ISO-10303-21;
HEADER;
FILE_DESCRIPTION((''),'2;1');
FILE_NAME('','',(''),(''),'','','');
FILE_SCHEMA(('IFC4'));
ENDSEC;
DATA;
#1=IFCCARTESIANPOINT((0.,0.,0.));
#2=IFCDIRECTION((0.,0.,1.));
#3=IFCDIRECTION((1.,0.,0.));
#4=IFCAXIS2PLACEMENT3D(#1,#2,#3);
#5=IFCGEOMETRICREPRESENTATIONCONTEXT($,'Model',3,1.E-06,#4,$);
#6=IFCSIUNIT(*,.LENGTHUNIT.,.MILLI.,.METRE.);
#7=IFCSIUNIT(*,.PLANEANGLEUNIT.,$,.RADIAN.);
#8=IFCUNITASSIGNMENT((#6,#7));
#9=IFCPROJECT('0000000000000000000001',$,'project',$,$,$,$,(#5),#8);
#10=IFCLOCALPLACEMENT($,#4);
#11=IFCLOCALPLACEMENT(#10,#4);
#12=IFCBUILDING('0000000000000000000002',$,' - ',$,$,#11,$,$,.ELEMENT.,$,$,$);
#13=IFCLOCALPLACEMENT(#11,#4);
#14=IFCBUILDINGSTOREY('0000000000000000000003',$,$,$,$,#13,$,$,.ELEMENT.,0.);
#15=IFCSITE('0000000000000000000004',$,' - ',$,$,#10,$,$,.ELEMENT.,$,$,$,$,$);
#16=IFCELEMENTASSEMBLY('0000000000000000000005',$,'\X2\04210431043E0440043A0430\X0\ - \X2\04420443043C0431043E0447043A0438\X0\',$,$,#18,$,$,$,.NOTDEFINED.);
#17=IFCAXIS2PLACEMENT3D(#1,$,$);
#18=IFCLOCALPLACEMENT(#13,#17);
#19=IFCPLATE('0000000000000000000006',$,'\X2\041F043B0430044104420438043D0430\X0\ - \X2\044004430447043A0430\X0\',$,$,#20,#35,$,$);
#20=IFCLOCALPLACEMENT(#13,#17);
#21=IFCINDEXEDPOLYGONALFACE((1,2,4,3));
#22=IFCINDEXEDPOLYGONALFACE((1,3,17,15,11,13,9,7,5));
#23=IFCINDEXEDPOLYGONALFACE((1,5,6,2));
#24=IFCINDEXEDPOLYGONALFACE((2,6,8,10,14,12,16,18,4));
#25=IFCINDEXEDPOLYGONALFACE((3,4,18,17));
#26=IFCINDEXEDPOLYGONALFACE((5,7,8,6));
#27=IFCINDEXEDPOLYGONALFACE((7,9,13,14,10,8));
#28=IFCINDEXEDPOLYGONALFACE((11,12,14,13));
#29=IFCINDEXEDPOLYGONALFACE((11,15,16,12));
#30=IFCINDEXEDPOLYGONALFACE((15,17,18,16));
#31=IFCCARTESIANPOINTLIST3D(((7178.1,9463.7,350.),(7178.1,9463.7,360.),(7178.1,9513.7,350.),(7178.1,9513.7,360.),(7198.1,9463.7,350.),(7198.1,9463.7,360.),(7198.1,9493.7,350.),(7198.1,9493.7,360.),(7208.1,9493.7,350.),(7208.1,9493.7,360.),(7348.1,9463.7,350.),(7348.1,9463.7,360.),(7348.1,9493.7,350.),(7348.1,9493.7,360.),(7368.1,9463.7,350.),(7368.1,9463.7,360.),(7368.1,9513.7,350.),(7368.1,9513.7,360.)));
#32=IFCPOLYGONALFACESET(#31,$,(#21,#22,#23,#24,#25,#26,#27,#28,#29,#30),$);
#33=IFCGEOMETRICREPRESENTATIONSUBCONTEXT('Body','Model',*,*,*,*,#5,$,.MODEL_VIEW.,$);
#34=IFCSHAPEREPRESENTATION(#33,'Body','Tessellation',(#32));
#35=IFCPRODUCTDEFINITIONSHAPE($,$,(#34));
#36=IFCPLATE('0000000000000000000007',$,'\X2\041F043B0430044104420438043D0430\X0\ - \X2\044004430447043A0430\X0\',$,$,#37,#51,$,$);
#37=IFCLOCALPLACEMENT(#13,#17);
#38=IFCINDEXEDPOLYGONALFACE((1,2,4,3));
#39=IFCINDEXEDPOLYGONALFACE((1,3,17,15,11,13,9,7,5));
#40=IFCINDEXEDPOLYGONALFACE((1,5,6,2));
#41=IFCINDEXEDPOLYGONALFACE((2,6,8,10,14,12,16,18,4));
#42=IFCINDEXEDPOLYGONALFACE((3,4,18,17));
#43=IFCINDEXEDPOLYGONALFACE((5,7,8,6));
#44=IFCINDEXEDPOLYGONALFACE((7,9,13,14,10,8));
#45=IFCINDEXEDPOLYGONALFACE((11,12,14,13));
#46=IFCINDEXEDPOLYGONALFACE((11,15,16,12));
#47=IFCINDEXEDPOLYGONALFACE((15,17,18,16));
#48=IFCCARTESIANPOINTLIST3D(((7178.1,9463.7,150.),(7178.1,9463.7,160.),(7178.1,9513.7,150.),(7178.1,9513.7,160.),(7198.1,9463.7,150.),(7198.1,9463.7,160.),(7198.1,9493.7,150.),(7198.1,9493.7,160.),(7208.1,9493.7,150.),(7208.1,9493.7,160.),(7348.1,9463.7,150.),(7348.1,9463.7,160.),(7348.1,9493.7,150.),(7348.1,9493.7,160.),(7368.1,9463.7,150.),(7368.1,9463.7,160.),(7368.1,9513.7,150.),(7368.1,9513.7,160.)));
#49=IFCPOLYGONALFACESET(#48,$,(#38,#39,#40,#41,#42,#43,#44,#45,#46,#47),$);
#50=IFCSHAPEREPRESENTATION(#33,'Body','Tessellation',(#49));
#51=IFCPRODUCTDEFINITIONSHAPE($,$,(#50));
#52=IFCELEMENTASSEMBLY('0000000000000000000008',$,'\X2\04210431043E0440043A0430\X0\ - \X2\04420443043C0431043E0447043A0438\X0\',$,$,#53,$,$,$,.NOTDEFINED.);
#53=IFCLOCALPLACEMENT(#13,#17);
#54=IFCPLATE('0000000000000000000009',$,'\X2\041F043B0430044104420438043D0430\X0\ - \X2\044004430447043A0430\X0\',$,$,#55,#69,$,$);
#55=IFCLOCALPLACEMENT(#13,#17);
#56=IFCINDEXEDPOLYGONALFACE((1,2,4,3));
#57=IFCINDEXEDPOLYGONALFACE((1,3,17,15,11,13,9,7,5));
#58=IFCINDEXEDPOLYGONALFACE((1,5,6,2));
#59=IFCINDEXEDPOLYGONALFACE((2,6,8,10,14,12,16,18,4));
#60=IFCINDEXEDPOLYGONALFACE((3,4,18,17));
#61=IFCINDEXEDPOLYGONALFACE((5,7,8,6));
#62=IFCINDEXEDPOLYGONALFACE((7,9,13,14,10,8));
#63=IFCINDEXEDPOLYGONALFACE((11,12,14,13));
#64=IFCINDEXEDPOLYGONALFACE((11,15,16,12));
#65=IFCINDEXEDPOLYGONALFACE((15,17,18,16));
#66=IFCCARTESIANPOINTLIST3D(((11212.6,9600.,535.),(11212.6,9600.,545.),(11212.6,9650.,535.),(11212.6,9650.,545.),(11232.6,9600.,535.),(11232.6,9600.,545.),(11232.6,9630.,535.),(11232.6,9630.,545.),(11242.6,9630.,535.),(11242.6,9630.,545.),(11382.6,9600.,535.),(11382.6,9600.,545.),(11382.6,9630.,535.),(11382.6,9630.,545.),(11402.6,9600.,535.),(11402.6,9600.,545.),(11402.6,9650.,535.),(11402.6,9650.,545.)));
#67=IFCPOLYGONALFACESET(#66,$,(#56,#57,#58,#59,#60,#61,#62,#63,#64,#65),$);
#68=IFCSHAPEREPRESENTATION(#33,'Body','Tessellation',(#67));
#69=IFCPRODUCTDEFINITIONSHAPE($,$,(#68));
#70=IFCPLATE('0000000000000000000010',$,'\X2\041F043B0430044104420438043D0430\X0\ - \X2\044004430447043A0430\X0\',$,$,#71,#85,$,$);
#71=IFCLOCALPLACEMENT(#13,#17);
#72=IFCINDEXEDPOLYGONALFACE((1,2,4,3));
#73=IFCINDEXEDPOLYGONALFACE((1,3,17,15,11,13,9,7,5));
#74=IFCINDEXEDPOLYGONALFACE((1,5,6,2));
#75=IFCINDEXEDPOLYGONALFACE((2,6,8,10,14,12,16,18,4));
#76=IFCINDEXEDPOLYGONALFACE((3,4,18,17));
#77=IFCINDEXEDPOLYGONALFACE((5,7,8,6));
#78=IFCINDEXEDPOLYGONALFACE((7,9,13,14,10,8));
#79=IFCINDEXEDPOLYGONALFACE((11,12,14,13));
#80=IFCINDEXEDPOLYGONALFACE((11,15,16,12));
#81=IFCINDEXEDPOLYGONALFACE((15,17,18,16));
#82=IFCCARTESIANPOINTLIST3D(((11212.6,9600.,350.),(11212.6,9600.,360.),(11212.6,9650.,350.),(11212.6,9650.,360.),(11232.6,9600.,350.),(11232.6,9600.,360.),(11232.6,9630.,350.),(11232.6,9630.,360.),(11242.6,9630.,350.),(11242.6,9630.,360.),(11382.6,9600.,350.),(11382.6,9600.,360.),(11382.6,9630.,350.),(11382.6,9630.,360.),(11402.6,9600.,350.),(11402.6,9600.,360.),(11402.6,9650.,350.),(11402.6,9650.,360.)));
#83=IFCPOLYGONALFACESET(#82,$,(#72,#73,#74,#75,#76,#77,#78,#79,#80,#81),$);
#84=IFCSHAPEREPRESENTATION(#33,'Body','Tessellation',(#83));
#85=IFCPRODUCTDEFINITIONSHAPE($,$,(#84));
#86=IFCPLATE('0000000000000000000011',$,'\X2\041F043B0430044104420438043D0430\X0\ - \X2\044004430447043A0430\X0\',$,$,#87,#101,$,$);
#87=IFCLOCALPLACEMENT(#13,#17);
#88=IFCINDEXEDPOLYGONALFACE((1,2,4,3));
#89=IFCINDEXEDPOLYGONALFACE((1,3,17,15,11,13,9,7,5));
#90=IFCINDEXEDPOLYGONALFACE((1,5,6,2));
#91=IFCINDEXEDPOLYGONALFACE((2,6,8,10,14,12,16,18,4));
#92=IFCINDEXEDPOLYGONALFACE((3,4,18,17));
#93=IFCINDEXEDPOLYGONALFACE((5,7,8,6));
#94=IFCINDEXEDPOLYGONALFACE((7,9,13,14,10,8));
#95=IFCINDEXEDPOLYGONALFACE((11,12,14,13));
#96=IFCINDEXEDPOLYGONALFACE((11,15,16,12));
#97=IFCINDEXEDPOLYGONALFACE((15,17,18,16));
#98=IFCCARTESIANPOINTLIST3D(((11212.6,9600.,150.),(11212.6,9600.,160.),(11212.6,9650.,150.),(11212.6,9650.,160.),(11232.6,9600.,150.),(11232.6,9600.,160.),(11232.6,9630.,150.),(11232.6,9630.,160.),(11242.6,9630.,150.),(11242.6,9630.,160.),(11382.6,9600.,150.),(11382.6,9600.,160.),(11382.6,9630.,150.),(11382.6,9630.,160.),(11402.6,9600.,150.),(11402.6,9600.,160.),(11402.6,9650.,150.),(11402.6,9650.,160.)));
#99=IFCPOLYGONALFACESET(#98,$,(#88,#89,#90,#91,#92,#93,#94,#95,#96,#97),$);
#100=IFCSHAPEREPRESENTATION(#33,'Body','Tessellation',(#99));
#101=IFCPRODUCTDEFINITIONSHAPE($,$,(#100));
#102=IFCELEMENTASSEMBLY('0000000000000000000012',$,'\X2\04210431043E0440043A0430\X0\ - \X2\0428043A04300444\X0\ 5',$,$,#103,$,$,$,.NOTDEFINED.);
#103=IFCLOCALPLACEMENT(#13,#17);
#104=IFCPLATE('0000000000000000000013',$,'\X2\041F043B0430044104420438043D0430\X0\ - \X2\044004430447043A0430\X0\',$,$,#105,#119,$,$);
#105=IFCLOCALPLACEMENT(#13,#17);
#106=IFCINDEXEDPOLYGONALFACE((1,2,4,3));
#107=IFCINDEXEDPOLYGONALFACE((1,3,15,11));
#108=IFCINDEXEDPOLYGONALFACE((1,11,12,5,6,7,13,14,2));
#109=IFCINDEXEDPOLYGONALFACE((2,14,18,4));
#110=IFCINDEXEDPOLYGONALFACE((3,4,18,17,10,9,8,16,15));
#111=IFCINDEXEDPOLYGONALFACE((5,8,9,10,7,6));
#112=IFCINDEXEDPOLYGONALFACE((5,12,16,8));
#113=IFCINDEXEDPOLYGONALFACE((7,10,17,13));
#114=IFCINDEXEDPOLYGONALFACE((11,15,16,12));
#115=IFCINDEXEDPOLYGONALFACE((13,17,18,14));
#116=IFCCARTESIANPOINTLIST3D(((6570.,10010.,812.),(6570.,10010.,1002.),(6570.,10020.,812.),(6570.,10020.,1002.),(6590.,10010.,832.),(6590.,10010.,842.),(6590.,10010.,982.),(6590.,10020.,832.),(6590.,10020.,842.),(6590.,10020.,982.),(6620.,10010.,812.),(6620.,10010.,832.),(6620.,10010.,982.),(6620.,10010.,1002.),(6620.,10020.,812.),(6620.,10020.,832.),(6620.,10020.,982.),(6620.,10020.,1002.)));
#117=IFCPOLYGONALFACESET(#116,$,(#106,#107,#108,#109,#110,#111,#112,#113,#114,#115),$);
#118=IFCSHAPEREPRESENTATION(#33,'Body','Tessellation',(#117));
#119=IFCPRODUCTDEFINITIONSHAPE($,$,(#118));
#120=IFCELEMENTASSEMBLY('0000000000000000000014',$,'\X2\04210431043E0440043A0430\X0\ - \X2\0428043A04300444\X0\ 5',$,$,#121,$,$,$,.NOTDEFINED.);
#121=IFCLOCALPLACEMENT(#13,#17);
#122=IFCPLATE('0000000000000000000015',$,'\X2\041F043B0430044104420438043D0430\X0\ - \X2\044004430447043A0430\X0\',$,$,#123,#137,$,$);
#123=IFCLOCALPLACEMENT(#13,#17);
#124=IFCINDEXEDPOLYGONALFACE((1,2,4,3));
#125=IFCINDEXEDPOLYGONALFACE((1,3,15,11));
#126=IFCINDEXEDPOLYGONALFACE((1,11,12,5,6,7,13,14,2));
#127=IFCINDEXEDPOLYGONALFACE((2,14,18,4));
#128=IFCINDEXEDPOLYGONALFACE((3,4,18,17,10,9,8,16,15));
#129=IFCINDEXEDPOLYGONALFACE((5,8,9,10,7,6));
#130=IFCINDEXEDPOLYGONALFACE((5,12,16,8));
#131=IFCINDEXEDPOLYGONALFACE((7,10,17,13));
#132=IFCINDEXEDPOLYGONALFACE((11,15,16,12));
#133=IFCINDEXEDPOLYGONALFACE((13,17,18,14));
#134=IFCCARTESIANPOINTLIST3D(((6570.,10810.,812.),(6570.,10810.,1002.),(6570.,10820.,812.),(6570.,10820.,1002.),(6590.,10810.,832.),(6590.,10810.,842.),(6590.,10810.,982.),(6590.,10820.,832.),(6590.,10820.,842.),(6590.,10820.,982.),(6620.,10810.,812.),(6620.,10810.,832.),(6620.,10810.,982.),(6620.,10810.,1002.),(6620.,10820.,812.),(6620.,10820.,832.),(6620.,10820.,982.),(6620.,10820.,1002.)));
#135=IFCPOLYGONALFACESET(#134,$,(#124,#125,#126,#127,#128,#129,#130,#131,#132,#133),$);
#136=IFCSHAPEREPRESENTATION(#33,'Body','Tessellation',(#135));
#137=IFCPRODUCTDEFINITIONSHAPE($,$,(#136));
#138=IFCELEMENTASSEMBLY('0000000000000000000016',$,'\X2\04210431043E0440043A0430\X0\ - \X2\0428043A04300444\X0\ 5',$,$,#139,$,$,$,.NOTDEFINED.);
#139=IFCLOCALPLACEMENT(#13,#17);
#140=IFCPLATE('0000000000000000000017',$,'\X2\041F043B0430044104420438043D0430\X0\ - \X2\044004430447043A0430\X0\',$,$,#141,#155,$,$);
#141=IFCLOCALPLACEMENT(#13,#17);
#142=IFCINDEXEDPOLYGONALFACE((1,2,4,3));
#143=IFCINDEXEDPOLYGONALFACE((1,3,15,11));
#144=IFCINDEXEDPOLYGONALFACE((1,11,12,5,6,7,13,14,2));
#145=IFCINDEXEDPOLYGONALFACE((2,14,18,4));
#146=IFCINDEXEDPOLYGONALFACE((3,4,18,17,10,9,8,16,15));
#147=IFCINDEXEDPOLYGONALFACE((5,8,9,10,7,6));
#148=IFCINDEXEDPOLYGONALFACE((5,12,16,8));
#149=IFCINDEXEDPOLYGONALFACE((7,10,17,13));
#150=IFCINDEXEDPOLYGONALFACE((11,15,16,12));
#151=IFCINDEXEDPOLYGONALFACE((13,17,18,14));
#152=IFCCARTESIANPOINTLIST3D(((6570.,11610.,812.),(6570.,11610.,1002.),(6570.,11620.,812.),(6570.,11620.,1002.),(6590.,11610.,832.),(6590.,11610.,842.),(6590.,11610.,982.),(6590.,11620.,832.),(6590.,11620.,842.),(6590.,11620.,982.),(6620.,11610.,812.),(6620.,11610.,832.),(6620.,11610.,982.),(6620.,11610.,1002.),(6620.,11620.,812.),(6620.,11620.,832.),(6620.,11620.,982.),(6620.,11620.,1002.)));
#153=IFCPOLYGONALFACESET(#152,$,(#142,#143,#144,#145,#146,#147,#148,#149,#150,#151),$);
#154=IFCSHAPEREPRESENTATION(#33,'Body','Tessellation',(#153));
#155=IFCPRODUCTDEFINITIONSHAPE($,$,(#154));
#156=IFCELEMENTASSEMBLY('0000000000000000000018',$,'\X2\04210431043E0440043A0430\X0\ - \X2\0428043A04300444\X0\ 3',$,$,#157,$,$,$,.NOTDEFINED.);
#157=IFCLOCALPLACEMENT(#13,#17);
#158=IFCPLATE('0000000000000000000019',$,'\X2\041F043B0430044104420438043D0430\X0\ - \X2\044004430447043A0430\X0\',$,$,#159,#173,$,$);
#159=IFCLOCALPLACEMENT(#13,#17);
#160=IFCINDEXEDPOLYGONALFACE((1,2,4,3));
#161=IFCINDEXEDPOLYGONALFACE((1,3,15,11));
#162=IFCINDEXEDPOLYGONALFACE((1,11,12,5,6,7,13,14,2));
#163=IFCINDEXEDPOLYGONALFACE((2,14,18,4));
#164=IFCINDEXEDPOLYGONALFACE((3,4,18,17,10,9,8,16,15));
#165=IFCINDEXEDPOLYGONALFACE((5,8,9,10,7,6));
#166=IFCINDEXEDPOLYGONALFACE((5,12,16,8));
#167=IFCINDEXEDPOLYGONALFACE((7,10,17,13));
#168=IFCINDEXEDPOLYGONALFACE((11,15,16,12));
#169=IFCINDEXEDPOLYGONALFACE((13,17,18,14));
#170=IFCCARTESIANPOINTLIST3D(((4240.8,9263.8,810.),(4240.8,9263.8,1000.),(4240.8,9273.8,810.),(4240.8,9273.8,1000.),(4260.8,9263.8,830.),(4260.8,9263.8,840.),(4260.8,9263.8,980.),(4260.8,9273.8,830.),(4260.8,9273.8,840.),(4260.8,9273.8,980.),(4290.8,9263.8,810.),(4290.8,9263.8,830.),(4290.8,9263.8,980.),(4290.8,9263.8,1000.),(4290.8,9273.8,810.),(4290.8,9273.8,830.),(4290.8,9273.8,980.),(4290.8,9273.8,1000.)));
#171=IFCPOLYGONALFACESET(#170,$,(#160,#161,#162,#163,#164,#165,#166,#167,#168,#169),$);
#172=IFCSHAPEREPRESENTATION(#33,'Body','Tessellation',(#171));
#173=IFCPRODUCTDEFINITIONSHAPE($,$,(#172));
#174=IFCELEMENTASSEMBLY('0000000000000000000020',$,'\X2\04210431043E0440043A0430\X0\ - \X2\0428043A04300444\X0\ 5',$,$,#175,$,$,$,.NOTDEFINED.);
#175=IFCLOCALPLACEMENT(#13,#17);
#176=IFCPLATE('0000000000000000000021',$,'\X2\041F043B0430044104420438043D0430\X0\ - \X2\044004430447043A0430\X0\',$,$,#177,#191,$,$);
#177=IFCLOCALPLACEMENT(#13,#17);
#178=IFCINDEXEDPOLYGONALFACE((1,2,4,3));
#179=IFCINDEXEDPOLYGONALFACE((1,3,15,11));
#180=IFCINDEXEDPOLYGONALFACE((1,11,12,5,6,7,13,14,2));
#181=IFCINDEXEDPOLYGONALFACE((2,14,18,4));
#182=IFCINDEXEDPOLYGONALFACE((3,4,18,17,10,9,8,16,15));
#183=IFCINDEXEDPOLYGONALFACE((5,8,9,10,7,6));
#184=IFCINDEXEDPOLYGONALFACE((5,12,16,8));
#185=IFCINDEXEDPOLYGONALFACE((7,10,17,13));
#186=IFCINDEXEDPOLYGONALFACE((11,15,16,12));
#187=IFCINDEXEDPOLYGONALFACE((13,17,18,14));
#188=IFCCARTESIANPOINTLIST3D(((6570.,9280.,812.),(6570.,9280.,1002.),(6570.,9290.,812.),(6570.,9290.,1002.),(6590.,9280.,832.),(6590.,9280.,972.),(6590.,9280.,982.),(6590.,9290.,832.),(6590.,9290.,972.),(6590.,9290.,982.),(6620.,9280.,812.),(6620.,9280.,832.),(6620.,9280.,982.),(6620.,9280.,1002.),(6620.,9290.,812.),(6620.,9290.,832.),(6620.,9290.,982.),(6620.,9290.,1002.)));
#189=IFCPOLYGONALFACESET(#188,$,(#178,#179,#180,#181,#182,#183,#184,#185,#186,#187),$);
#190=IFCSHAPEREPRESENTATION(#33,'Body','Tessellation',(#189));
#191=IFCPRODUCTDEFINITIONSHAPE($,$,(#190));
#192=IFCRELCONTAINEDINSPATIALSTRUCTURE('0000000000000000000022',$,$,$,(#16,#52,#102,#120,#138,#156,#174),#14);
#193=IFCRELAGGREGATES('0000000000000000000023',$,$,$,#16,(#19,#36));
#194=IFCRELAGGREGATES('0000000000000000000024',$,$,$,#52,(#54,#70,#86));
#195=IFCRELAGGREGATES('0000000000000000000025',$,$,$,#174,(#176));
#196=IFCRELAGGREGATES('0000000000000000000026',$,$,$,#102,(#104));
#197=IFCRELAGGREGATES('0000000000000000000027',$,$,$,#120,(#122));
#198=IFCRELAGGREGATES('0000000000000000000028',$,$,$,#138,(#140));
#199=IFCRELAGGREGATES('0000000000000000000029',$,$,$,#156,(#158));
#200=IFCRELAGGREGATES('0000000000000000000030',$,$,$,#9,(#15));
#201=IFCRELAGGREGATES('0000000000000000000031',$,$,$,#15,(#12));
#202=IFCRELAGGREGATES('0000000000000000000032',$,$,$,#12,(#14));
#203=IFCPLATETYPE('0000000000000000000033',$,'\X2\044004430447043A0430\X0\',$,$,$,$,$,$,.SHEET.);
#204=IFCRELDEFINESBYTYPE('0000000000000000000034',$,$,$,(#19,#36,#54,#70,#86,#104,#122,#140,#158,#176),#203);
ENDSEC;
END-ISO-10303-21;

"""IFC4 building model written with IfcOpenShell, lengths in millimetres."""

from ifc_helpers import new_model, si_unit, frame, origin_with_axes, place, context, subcontext, project, spatial, line, indexed_curve, outline, extrude, source, transform, mapped, type_object, element, aggregate, save


model = new_model("IFC4")

# Units and contexts
model_context = context("Model", 3, precision=1e-06, world=origin_with_axes())
body_context = subcontext(model_context, "Body", "Model", "MODEL_VIEW")
ifc_project = project(units=[si_unit("LENGTHUNIT", "METRE", prefix="MILLI"), si_unit("PLANEANGLEUNIT", "RADIAN")], contexts=[model_context])

# Site, building, storey
site_placement = place(None, origin_with_axes())
site = spatial("IfcSite", under=ifc_project, at=site_placement, Name=" - ", CompositionType="ELEMENT")
building_placement = place(site_placement, origin_with_axes())
building = spatial("IfcBuilding", under=site, at=building_placement, Name=" - ", CompositionType="ELEMENT")
storey_placement = place(building_placement, origin_with_axes())
storey = spatial("IfcBuildingStorey", under=building, at=storey_placement, CompositionType="ELEMENT", Elevation=0.0)

# Shared definitions
plate_type = type_object("IfcPlateType", Name="ручка", PredefinedType="SHEET")
shared_shape_1 = source(origin_with_axes(), body_context, "Body", "SweptSolid", [
    extrude(outline(indexed_curve([(-95.0, -25.0), (-75.0, -25.0), (-75.0, 5.0), (-65.0, 5.0), (75.0, 5.0), (75.0, -25.0), (95.0, -25.0), (95.0, 25.0), (-95.0, 25.0)], segments=[line(1, 2), line(2, 3), line(3, 4), line(4, 5), line(5, 6), line(6, 7), line(7, 8), line(8, 9), line(9, 1)])), origin_with_axes(), (0.0, 0.0, 1.0), 10.0),
])

# Element assemblies, plates
assembly_1_placement = place(storey_placement, frame((7473.1, 9463.7, 0.0), z_axis=(0.0, 0.0, 1.0), x_axis=(-1.0, 0.0, 0.0)))
assembly_1 = element("IfcElementAssembly", 1, at=assembly_1_placement, inside=storey, Name="Сборка - тумбочки", PredefinedType="NOTDEFINED")
plate_1_placement = place(assembly_1_placement, frame((200.0, -25.0, 350.0), z_axis=(0.0, 0.0, 1.0), x_axis=(-1.0, 0.0, 0.0)))
plate_1 = element("IfcPlate", 2, at=plate_1_placement, type_object=plate_type, Name="Пластина - ручка", context=body_context, shape_type="MappedRepresentation", body=[
    mapped(shared_shape_1, transform((0.0, 0.0, 0.0), x_axis=(1.0, 0.0, 0.0), y_axis=(0.0, 1.0, 0.0), z_axis=(0.0, 0.0, 1.0), scale=1.0)),
])
plate_2_placement = place(assembly_1_placement, frame((200.0, -25.0, 150.0), z_axis=(0.0, 0.0, 1.0), x_axis=(-1.0, 0.0, 0.0)))
plate_2 = element("IfcPlate", 3, at=plate_2_placement, type_object=plate_type, Name="Пластина - ручка", context=body_context, shape_type="MappedRepresentation", body=[
    mapped(shared_shape_1, transform((0.0, 0.0, 0.0), x_axis=(1.0, 0.0, 0.0), y_axis=(0.0, 1.0, 0.0), z_axis=(0.0, 0.0, 1.0), scale=1.0)),
])
aggregate(assembly_1, [plate_1, plate_2])
assembly_2_placement = place(storey_placement, frame((11507.6, 9600.0, 0.0), z_axis=(0.0, 0.0, 1.0), x_axis=(-1.0, 0.0, 0.0)))
assembly_2 = element("IfcElementAssembly", 4, at=assembly_2_placement, inside=storey, Name="Сборка - тумбочки", PredefinedType="NOTDEFINED")
plate_3_placement = place(assembly_2_placement, frame((200.0, -25.0, 535.0), z_axis=(0.0, 0.0, 1.0), x_axis=(-1.0, 0.0, 0.0)))
plate_3 = element("IfcPlate", 5, at=plate_3_placement, type_object=plate_type, Name="Пластина - ручка", context=body_context, shape_type="MappedRepresentation", body=[
    mapped(shared_shape_1, transform((0.0, 0.0, 0.0), x_axis=(1.0, 0.0, 0.0), y_axis=(0.0, 1.0, 0.0), z_axis=(0.0, 0.0, 1.0), scale=1.0)),
])
plate_4_placement = place(assembly_2_placement, frame((200.0, -25.0, 350.0), z_axis=(0.0, 0.0, 1.0), x_axis=(-1.0, 0.0, 0.0)))
plate_4 = element("IfcPlate", 6, at=plate_4_placement, type_object=plate_type, Name="Пластина - ручка", context=body_context, shape_type="MappedRepresentation", body=[
    mapped(shared_shape_1, transform((0.0, 0.0, 0.0), x_axis=(1.0, 0.0, 0.0), y_axis=(0.0, 1.0, 0.0), z_axis=(0.0, 0.0, 1.0), scale=1.0)),
])
plate_5_placement = place(assembly_2_placement, frame((200.0, -25.0, 150.0), z_axis=(0.0, 0.0, 1.0), x_axis=(-1.0, 0.0, 0.0)))
plate_5 = element("IfcPlate", 7, at=plate_5_placement, type_object=plate_type, Name="Пластина - ручка", context=body_context, shape_type="MappedRepresentation", body=[
    mapped(shared_shape_1, transform((0.0, 0.0, 0.0), x_axis=(1.0, 0.0, 0.0), y_axis=(0.0, 1.0, 0.0), z_axis=(0.0, 0.0, 1.0), scale=1.0)),
])
aggregate(assembly_2, [plate_3, plate_4, plate_5])

# Element assemblies, plates
assembly_3_placement = place(storey_placement, frame((6620.0, 10450.0, 2.0), z_axis=(0.0, 0.0, 1.0), x_axis=(0.0, -1.0, 0.0)))
assembly_3 = element("IfcElementAssembly", 8, at=assembly_3_placement, inside=storey, Name="Сборка - Шкаф 5", PredefinedType="NOTDEFINED")
shared_shape_2 = source(origin_with_axes(), body_context, "Body", "SweptSolid", [
    extrude(outline(indexed_curve([(-95.0, -25.0), (-75.0, -25.0), (-75.0, 5.0), (-65.0, 5.0), (75.0, 5.0), (75.0, -25.0), (95.0, -25.0), (95.0, 25.0), (-95.0, 25.0)], segments=[line(1, 2), line(2, 3), line(3, 4), line(4, 5), line(5, 6), line(6, 7), line(7, 8), line(8, 9), line(9, 1)])), origin_with_axes(), (0.0, 0.0, 1.0), 10.0),
])
plate_6_placement = place(assembly_3_placement, frame((430.0, -25.0, 905.0), z_axis=(1.0, 0.0, 0.0), x_axis=(0.0, 0.0, 1.0)))
plate_6 = element("IfcPlate", 9, at=plate_6_placement, type_object=plate_type, Name="Пластина - ручка", context=body_context, shape_type="MappedRepresentation", body=[
    mapped(shared_shape_2, transform((0.0, 0.0, 0.0), x_axis=(1.0, 0.0, 0.0), y_axis=(0.0, 1.0, 0.0), z_axis=(0.0, 0.0, 1.0), scale=1.0)),
])
assembly_4_placement = place(storey_placement, frame((6620.0, 11250.0, 2.0), z_axis=(0.0, 0.0, 1.0), x_axis=(0.0, -1.0, 0.0)))
assembly_4 = element("IfcElementAssembly", 10, at=assembly_4_placement, inside=storey, Name="Сборка - Шкаф 5", PredefinedType="NOTDEFINED")
plate_7_placement = place(assembly_4_placement, frame((430.0, -25.0, 905.0), z_axis=(1.0, 0.0, 0.0), x_axis=(0.0, 0.0, 1.0)))
plate_7 = element("IfcPlate", 11, at=plate_7_placement, type_object=plate_type, Name="Пластина - ручка", context=body_context, shape_type="MappedRepresentation", body=[
    mapped(shared_shape_2, transform((0.0, 0.0, 0.0), x_axis=(1.0, 0.0, 0.0), y_axis=(0.0, 1.0, 0.0), z_axis=(0.0, 0.0, 1.0), scale=1.0)),
])
assembly_5_placement = place(storey_placement, frame((6620.0, 12050.0, 2.0), z_axis=(0.0, 0.0, 1.0), x_axis=(0.0, -1.0, 0.0)))
assembly_5 = element("IfcElementAssembly", 12, at=assembly_5_placement, inside=storey, Name="Сборка - Шкаф 5", PredefinedType="NOTDEFINED")
plate_8_placement = place(assembly_5_placement, frame((430.0, -25.0, 905.0), z_axis=(1.0, 0.0, 0.0), x_axis=(0.0, 0.0, 1.0)))
plate_8 = element("IfcPlate", 13, at=plate_8_placement, type_object=plate_type, Name="Пластина - ручка", context=body_context, shape_type="MappedRepresentation", body=[
    mapped(shared_shape_2, transform((0.0, 0.0, 0.0), x_axis=(1.0, 0.0, 0.0), y_axis=(0.0, 1.0, 0.0), z_axis=(0.0, 0.0, 1.0), scale=1.0)),
])
assembly_6_placement = place(storey_placement, frame((4290.8, 9903.8, 0.0), z_axis=(0.0, 0.0, 1.0), x_axis=(0.0, -1.0, 0.0)))
assembly_6 = element("IfcElementAssembly", 14, at=assembly_6_placement, inside=storey, Name="Сборка - Шкаф 3", PredefinedType="NOTDEFINED")
plate_9_placement = place(assembly_6_placement, frame((630.0, -25.0, 905.0), z_axis=(1.0, 0.0, 0.0), x_axis=(0.0, 0.0, 1.0)))
plate_9 = element("IfcPlate", 15, at=plate_9_placement, type_object=plate_type, Name="Пластина - ручка", context=body_context, shape_type="MappedRepresentation", body=[
    mapped(shared_shape_2, transform((0.0, 0.0, 0.0), x_axis=(1.0, 0.0, 0.0), y_axis=(0.0, 1.0, 0.0), z_axis=(0.0, 0.0, 1.0), scale=1.0)),
])
assembly_7_placement = place(storey_placement, frame((6620.0, 9650.0, 2.0), z_axis=(0.0, 0.0, 1.0), x_axis=(0.0, -1.0, 0.0)))
assembly_7 = element("IfcElementAssembly", 16, at=assembly_7_placement, inside=storey, Name="Сборка - Шкаф 5", PredefinedType="NOTDEFINED")
shared_shape_3 = source(origin_with_axes(), body_context, "Body", "SweptSolid", [
    extrude(outline(indexed_curve([(-95.0, -25.0), (-75.0, -25.0), (-75.0, 5.0), (-65.0, 5.0), (75.0, 5.0), (75.0, -25.0), (95.0, -25.0), (95.0, 25.0), (-95.0, 25.0)], segments=[line(1, 2), line(2, 3), line(3, 4), line(4, 5), line(5, 6), line(6, 7), line(7, 8), line(8, 9), line(9, 1)])), origin_with_axes(), (0.0, 0.0, 1.0), 10.0),
])
plate_10_placement = place(assembly_7_placement, frame((370.0, -25.0, 905.0), z_axis=(-1.0, 0.0, 0.0), x_axis=(0.0, 0.0, -1.0)))
plate_10 = element("IfcPlate", 17, at=plate_10_placement, type_object=plate_type, Name="Пластина - ручка", context=body_context, shape_type="MappedRepresentation", body=[
    mapped(shared_shape_3, transform((0.0, 0.0, 0.0), x_axis=(1.0, 0.0, 0.0), y_axis=(0.0, 1.0, 0.0), z_axis=(0.0, 0.0, 1.0), scale=1.0)),
])
aggregate(assembly_7, [plate_10])

aggregate(assembly_3, [plate_6])
aggregate(assembly_4, [plate_7])
aggregate(assembly_5, [plate_8])
aggregate(assembly_6, [plate_9])

save(model, "model.ifc")
